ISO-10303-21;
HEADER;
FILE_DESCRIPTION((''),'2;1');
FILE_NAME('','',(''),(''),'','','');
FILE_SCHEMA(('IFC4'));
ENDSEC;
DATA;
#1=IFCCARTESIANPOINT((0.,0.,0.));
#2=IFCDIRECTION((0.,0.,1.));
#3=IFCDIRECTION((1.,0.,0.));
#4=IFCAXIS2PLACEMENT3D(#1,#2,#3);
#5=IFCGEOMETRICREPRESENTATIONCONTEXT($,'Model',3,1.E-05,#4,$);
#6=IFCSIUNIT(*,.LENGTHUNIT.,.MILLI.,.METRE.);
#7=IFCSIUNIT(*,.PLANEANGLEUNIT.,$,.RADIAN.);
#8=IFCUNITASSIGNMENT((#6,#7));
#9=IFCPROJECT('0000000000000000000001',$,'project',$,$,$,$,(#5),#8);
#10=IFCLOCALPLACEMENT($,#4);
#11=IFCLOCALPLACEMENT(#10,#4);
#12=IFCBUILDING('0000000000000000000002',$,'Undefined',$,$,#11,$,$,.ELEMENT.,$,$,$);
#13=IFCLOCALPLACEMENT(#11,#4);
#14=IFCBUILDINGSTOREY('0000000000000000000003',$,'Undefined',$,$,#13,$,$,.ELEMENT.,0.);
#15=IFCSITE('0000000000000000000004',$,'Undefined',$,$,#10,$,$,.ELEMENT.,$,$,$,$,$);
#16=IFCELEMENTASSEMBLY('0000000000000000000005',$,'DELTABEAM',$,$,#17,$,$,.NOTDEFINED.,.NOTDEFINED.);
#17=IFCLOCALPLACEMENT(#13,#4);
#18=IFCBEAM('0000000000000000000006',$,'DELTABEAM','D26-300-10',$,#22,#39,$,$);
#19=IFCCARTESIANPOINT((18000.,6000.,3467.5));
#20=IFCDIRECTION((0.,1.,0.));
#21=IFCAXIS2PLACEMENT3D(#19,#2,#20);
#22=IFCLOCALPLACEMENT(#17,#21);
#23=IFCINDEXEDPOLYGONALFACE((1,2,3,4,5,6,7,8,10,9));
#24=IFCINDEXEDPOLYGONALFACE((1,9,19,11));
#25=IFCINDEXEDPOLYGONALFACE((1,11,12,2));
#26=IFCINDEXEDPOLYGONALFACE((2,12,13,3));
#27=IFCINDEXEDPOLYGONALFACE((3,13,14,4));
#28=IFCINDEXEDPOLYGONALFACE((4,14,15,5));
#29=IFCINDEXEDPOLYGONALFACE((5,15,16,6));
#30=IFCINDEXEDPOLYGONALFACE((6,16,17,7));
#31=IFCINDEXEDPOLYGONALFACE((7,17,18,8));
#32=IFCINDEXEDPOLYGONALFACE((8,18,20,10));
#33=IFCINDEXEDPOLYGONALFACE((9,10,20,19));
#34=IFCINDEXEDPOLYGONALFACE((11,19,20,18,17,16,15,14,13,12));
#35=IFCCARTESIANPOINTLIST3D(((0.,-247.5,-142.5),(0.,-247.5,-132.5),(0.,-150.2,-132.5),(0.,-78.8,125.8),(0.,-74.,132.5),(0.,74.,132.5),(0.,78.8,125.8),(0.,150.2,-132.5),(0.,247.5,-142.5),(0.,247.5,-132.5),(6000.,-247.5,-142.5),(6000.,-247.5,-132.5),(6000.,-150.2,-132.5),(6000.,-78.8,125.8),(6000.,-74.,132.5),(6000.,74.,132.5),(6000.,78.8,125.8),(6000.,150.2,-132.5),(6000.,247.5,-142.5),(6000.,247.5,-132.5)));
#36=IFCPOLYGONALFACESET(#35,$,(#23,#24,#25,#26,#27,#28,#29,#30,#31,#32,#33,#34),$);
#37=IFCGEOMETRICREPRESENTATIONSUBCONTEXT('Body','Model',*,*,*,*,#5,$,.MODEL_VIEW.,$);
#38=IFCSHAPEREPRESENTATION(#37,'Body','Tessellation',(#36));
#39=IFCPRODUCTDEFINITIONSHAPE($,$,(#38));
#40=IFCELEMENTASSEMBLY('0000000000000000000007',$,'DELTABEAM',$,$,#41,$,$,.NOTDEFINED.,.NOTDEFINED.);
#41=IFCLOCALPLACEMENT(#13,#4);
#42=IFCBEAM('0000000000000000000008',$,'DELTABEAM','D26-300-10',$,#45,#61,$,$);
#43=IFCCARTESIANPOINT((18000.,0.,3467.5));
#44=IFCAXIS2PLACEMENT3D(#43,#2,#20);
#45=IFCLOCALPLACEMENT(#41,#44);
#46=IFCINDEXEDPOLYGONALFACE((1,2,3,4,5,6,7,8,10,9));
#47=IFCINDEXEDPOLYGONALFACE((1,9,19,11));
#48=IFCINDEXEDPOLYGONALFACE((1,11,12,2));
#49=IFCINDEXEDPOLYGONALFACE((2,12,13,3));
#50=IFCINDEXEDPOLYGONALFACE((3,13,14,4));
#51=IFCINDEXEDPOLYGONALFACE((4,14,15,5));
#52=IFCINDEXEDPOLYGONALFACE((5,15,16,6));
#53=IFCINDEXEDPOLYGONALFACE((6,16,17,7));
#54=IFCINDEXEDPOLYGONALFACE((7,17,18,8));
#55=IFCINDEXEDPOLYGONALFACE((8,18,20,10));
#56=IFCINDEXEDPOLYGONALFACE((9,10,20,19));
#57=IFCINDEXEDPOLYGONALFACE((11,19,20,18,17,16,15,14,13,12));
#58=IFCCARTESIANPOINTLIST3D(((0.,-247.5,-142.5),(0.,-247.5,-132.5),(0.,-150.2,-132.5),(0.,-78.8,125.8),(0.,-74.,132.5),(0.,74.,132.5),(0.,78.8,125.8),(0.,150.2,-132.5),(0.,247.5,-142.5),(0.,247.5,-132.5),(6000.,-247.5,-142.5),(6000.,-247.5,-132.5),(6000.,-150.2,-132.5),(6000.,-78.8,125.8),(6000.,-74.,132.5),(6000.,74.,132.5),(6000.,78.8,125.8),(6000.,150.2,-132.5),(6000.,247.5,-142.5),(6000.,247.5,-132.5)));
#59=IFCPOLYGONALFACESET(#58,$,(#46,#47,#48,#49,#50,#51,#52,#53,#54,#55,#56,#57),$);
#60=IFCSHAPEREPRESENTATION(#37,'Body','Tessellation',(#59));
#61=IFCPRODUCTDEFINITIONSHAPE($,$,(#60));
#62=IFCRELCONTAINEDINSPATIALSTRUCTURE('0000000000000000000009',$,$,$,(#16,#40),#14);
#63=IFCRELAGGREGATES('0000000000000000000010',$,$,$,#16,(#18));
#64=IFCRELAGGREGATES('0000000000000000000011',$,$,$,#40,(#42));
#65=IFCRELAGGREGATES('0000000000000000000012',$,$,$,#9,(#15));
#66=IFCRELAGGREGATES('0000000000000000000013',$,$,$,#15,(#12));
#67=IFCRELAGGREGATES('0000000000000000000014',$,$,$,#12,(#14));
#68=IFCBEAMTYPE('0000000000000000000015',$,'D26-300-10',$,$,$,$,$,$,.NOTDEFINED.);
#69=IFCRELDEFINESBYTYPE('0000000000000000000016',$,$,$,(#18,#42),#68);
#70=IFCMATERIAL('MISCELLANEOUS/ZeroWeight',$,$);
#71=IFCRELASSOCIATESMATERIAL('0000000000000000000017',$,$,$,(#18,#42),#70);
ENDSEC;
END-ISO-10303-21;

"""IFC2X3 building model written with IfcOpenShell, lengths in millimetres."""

from ifc_helpers import new_model, si_unit, frame, origin_with_axes, place, context, subcontext, project, spatial, polyline, outline, extrude, material, type_object, element, aggregate, save


model = new_model("IFC2X3")

# Units and contexts
model_context = context("Model", 3, precision=1e-05, world=origin_with_axes())
body_context = subcontext(model_context, "Body", "Model", "MODEL_VIEW")
ifc_project = project(units=[si_unit("LENGTHUNIT", "METRE", prefix="MILLI"), si_unit("PLANEANGLEUNIT", "RADIAN")], contexts=[model_context])

# Site, building, storey
site_placement = place(None, origin_with_axes())
site = spatial("IfcSite", under=ifc_project, at=site_placement, Name="Undefined", CompositionType="ELEMENT")
building_placement = place(site_placement, origin_with_axes())
building = spatial("IfcBuilding", under=site, at=building_placement, Name="Undefined", CompositionType="ELEMENT")
storey_placement = place(building_placement, origin_with_axes())
storey = spatial("IfcBuildingStorey", under=building, at=storey_placement, Name="Undefined", CompositionType="ELEMENT", Elevation=0.0)

# Element assemblies, beams
assembly_1_placement = place(storey_placement, origin_with_axes())
assembly_1 = element("IfcElementAssembly", 1, at=assembly_1_placement, inside=storey, Name="DELTABEAM", AssemblyPlace="NOTDEFINED", PredefinedType="NOTDEFINED")
ifc_material_1 = material(Name="MISCELLANEOUS/ZeroWeight")
beam_type_1 = type_object("IfcBeamType", Name="D26-300-10", PredefinedType="NOTDEFINED")
beam_1_placement = place(assembly_1_placement, frame((18000.0, 6000.0, 3467.5), z_axis=(0.0, 0.0, 1.0), x_axis=(0.0, 1.0, 0.0)))
beam_1 = element("IfcBeam", 2, at=beam_1_placement, type_object=beam_type_1, material=ifc_material_1, Name="DELTABEAM", Description="D26-300-10", context=body_context, shape_type="SweptSolid", body=[
    extrude(outline(polyline([(-75.1, 120.5), (-145.0, -132.5), (247.5, -132.5), (247.5, -142.5), (-247.5, -142.5), (-247.5, -132.5), (-150.2, -132.5), (-78.8, 125.8), (-74.0, 132.5), (74.0, 132.5), (78.8, 125.8), (150.2, -132.5), (145.0, -132.5), (75.1, 120.5), (-75.1, 120.5)])), frame((6000.0, 0.0, 0.0), z_axis=(-1.0, 0.0, 0.0), x_axis=(0.0, -1.0, 0.0)), (0.0, 0.0, 1.0), 6000.0),
])
aggregate(assembly_1, [beam_1])
assembly_2_placement = place(storey_placement, origin_with_axes())
assembly_2 = element("IfcElementAssembly", 3, at=assembly_2_placement, inside=storey, Name="DELTABEAM", AssemblyPlace="NOTDEFINED", PredefinedType="NOTDEFINED")
beam_2_placement = place(assembly_2_placement, frame((18000.0, 0.0, 3467.5), z_axis=(0.0, 0.0, 1.0), x_axis=(0.0, 1.0, 0.0)))
beam_2 = element("IfcBeam", 4, at=beam_2_placement, type_object=beam_type_1, material=ifc_material_1, Name="DELTABEAM", Description="D26-300-10", context=body_context, shape_type="SweptSolid", body=[
    extrude(outline(polyline([(-75.1, 120.5), (-145.0, -132.5), (247.5, -132.5), (247.5, -142.5), (-247.5, -142.5), (-247.5, -132.5), (-150.2, -132.5), (-78.8, 125.8), (-74.0, 132.5), (74.0, 132.5), (78.8, 125.8), (150.2, -132.5), (145.0, -132.5), (75.1, 120.5), (-75.1, 120.5)])), frame((6000.0, 0.0, 0.0), z_axis=(-1.0, 0.0, 0.0), x_axis=(0.0, -1.0, 0.0)), (0.0, 0.0, 1.0), 6000.0),
])
aggregate(assembly_2, [beam_2])

save(model, "model.ifc")
